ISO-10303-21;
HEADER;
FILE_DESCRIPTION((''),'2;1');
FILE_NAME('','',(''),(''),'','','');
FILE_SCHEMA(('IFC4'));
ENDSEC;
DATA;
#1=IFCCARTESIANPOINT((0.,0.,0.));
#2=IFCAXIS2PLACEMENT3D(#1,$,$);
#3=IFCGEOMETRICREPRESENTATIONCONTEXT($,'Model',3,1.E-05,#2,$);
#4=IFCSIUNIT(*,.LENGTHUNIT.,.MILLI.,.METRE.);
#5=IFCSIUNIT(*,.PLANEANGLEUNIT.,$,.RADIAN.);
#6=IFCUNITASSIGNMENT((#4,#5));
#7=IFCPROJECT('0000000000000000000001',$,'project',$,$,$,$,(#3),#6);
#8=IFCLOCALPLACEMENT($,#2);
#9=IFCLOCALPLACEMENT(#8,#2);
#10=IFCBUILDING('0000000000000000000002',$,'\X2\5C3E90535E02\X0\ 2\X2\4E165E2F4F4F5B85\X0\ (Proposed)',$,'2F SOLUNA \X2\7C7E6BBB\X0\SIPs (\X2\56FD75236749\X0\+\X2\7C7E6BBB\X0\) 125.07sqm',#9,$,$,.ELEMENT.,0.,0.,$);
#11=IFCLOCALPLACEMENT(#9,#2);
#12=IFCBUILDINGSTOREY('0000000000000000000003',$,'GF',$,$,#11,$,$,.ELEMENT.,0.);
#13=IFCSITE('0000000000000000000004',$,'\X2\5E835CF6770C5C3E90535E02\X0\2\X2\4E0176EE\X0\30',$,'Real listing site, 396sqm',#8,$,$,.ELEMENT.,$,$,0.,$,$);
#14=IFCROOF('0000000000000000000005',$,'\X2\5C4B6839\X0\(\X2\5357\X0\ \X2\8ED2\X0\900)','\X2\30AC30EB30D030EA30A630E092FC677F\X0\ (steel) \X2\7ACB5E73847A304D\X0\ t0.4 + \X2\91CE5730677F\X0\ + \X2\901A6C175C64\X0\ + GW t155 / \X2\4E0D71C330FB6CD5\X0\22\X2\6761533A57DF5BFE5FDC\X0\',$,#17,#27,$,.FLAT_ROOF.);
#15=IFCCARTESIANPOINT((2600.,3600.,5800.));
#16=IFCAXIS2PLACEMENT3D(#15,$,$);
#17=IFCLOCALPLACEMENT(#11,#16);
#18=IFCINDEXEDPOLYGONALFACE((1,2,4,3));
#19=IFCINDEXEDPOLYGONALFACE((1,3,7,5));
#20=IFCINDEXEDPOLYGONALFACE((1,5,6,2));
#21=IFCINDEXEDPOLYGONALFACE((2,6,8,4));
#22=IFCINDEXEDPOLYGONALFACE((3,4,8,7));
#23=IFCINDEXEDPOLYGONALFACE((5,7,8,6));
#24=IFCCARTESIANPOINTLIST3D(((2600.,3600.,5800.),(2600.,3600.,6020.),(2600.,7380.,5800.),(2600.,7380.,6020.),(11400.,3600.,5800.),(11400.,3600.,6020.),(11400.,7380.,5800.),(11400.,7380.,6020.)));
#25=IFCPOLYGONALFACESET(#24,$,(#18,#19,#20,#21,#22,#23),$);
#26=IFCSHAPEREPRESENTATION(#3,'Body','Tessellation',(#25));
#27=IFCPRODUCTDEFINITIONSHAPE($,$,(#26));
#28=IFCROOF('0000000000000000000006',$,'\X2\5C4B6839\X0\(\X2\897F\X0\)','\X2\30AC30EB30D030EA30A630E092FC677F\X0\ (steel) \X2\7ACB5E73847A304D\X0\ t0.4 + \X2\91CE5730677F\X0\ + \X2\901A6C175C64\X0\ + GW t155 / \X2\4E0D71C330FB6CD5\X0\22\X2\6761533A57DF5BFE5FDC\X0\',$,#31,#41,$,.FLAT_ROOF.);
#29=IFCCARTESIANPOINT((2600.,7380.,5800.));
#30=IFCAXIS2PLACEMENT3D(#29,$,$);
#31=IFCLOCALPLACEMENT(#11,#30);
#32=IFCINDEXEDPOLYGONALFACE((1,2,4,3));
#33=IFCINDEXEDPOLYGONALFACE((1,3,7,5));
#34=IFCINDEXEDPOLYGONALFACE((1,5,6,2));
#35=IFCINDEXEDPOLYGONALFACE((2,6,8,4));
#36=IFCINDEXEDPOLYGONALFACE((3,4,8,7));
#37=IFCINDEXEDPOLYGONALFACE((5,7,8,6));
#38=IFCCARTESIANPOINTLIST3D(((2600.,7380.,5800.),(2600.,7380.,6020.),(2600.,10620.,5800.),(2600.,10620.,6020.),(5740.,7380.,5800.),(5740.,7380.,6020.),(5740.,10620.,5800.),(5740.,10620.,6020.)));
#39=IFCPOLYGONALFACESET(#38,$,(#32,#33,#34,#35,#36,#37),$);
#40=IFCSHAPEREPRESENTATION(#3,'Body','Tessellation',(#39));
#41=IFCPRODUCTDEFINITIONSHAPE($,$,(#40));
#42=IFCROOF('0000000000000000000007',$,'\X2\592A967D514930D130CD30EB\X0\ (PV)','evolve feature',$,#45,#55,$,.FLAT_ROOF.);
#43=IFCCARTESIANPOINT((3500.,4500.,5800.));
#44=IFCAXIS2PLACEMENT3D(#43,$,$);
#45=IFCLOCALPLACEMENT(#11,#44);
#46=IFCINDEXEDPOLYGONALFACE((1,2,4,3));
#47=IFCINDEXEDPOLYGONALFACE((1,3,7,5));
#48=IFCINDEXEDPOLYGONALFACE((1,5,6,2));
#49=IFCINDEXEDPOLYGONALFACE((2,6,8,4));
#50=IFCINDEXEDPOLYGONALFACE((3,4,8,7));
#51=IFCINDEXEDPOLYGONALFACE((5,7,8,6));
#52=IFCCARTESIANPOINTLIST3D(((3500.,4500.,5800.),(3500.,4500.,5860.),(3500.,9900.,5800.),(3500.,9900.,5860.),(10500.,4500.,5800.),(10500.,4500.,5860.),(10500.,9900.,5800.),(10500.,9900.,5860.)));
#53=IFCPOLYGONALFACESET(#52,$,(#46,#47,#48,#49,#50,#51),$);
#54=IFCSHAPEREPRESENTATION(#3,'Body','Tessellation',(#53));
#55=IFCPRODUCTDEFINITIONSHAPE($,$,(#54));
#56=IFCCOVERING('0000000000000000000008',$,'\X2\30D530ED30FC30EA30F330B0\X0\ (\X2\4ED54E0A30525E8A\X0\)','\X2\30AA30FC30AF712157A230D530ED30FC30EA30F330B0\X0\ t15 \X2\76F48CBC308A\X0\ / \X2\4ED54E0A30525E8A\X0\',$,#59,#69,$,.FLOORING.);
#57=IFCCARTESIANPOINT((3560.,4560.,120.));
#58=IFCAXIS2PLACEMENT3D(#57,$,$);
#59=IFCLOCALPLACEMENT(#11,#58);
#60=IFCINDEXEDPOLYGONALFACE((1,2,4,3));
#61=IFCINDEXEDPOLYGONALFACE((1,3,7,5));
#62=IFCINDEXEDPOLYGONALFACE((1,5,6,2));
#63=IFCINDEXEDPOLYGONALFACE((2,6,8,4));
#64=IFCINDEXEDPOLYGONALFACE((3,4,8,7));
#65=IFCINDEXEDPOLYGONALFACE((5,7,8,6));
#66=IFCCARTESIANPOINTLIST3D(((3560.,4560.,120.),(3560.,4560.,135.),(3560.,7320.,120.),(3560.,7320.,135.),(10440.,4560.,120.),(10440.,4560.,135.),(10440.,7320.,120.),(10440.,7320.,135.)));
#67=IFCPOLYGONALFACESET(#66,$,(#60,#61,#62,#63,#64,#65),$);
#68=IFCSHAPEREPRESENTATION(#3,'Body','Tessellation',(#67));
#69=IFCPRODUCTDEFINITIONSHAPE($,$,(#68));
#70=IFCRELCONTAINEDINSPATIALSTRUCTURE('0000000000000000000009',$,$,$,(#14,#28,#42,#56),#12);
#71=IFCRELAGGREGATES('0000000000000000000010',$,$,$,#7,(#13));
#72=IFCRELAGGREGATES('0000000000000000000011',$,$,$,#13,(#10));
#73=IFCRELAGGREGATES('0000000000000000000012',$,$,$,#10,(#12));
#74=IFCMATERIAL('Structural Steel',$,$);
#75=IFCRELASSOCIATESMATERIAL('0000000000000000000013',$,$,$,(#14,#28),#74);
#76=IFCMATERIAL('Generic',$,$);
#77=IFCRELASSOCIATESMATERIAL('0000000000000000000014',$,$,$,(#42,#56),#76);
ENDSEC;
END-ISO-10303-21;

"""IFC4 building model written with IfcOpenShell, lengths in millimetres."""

from ifc_helpers import new_model, si_unit, frame, frame_2d, origin, place, context, project, spatial, rectangle, extrude, material, element, save


model = new_model("IFC4")

# Units and contexts
model_context = context("Model", 3, precision=1e-05, world=origin())
ifc_project = project(units=[si_unit("LENGTHUNIT", "METRE", prefix="MILLI"), si_unit("PLANEANGLEUNIT", "RADIAN")], contexts=[model_context])

# Site, building, storey
site_placement = place(None, origin())
site = spatial("IfcSite", under=ifc_project, at=site_placement, Name="広島県尾道市2丁目30", ObjectType="Real listing site, 396sqm", CompositionType="ELEMENT", RefElevation=0.0)
building_placement = place(site_placement, origin())
building = spatial("IfcBuilding", under=site, at=building_placement, Name="尾道市 2世帯住宅 (Proposed)", ObjectType="2F SOLUNA 籾殻SIPs (国産杉+籾殻) 125.07sqm", CompositionType="ELEMENT", ElevationOfRefHeight=0.0, ElevationOfTerrain=0.0)
storey_placement = place(building_placement, origin())
storey = spatial("IfcBuildingStorey", under=building, at=storey_placement, Name="GF", CompositionType="ELEMENT", Elevation=0.0)

# Shared definitions
ifc_material_1 = material(Name="Generic")

# Roofs
ifc_material_2 = material(Name="Structural Steel")
roof_1_placement = place(storey_placement, frame((2600.0, 3600.0, 5800.0)))
element("IfcRoof", 1, at=roof_1_placement, inside=storey, material=ifc_material_2, Name="屋根(南 軒900)", Description="ガルバリウム鋼板 (steel) 立平葺き t0.4 + 野地板 + 通気層 + GW t155 / 不燃・法22条区域対応", PredefinedType="FLAT_ROOF", context=model_context, shape_type="SweptSolid", body=[
    extrude(rectangle(XDim=8800.0, YDim=3780.0, at=frame_2d((4400.0, 1890.0))), frame((2600.0, 3600.0, 5800.0)), (0.0, 0.0, 1.0), 220.0),
])
roof_2_placement = place(storey_placement, frame((2600.0, 7380.0, 5800.0)))
element("IfcRoof", 2, at=roof_2_placement, inside=storey, material=ifc_material_2, Name="屋根(西)", Description="ガルバリウム鋼板 (steel) 立平葺き t0.4 + 野地板 + 通気層 + GW t155 / 不燃・法22条区域対応", PredefinedType="FLAT_ROOF", context=model_context, shape_type="SweptSolid", body=[
    extrude(rectangle(XDim=3140.0, YDim=3240.0, at=frame_2d((1570.0, 1620.0))), frame((2600.0, 7380.0, 5800.0)), (0.0, 0.0, 1.0), 220.0),
])
roof_3_placement = place(storey_placement, frame((3500.0, 4500.0, 5800.0)))
element("IfcRoof", 3, at=roof_3_placement, inside=storey, material=ifc_material_1, Name="太陽光パネル (PV)", Description="evolve feature", PredefinedType="FLAT_ROOF", context=model_context, shape_type="SweptSolid", body=[
    extrude(rectangle(XDim=7000.0, YDim=5400.0, at=frame_2d((3500.0, 2700.0))), frame((3500.0, 4500.0, 5800.0)), (0.0, 0.0, 1.0), 60.0),
])

# Covering
covering_placement = place(storey_placement, frame((3560.0, 4560.0, 120.0)))
element("IfcCovering", 4, at=covering_placement, inside=storey, material=ifc_material_1, Name="フローリング (仕上げ床)", Description="オーク無垢フローリング t15 直貼り / 仕上げ床", PredefinedType="FLOORING", context=model_context, shape_type="SweptSolid", body=[
    extrude(rectangle(XDim=6880.0, YDim=2760.0, at=frame_2d((3440.0, 1380.0))), frame((3560.0, 4560.0, 120.0)), (0.0, 0.0, 1.0), 15.0),
])

save(model, "model.ifc")
